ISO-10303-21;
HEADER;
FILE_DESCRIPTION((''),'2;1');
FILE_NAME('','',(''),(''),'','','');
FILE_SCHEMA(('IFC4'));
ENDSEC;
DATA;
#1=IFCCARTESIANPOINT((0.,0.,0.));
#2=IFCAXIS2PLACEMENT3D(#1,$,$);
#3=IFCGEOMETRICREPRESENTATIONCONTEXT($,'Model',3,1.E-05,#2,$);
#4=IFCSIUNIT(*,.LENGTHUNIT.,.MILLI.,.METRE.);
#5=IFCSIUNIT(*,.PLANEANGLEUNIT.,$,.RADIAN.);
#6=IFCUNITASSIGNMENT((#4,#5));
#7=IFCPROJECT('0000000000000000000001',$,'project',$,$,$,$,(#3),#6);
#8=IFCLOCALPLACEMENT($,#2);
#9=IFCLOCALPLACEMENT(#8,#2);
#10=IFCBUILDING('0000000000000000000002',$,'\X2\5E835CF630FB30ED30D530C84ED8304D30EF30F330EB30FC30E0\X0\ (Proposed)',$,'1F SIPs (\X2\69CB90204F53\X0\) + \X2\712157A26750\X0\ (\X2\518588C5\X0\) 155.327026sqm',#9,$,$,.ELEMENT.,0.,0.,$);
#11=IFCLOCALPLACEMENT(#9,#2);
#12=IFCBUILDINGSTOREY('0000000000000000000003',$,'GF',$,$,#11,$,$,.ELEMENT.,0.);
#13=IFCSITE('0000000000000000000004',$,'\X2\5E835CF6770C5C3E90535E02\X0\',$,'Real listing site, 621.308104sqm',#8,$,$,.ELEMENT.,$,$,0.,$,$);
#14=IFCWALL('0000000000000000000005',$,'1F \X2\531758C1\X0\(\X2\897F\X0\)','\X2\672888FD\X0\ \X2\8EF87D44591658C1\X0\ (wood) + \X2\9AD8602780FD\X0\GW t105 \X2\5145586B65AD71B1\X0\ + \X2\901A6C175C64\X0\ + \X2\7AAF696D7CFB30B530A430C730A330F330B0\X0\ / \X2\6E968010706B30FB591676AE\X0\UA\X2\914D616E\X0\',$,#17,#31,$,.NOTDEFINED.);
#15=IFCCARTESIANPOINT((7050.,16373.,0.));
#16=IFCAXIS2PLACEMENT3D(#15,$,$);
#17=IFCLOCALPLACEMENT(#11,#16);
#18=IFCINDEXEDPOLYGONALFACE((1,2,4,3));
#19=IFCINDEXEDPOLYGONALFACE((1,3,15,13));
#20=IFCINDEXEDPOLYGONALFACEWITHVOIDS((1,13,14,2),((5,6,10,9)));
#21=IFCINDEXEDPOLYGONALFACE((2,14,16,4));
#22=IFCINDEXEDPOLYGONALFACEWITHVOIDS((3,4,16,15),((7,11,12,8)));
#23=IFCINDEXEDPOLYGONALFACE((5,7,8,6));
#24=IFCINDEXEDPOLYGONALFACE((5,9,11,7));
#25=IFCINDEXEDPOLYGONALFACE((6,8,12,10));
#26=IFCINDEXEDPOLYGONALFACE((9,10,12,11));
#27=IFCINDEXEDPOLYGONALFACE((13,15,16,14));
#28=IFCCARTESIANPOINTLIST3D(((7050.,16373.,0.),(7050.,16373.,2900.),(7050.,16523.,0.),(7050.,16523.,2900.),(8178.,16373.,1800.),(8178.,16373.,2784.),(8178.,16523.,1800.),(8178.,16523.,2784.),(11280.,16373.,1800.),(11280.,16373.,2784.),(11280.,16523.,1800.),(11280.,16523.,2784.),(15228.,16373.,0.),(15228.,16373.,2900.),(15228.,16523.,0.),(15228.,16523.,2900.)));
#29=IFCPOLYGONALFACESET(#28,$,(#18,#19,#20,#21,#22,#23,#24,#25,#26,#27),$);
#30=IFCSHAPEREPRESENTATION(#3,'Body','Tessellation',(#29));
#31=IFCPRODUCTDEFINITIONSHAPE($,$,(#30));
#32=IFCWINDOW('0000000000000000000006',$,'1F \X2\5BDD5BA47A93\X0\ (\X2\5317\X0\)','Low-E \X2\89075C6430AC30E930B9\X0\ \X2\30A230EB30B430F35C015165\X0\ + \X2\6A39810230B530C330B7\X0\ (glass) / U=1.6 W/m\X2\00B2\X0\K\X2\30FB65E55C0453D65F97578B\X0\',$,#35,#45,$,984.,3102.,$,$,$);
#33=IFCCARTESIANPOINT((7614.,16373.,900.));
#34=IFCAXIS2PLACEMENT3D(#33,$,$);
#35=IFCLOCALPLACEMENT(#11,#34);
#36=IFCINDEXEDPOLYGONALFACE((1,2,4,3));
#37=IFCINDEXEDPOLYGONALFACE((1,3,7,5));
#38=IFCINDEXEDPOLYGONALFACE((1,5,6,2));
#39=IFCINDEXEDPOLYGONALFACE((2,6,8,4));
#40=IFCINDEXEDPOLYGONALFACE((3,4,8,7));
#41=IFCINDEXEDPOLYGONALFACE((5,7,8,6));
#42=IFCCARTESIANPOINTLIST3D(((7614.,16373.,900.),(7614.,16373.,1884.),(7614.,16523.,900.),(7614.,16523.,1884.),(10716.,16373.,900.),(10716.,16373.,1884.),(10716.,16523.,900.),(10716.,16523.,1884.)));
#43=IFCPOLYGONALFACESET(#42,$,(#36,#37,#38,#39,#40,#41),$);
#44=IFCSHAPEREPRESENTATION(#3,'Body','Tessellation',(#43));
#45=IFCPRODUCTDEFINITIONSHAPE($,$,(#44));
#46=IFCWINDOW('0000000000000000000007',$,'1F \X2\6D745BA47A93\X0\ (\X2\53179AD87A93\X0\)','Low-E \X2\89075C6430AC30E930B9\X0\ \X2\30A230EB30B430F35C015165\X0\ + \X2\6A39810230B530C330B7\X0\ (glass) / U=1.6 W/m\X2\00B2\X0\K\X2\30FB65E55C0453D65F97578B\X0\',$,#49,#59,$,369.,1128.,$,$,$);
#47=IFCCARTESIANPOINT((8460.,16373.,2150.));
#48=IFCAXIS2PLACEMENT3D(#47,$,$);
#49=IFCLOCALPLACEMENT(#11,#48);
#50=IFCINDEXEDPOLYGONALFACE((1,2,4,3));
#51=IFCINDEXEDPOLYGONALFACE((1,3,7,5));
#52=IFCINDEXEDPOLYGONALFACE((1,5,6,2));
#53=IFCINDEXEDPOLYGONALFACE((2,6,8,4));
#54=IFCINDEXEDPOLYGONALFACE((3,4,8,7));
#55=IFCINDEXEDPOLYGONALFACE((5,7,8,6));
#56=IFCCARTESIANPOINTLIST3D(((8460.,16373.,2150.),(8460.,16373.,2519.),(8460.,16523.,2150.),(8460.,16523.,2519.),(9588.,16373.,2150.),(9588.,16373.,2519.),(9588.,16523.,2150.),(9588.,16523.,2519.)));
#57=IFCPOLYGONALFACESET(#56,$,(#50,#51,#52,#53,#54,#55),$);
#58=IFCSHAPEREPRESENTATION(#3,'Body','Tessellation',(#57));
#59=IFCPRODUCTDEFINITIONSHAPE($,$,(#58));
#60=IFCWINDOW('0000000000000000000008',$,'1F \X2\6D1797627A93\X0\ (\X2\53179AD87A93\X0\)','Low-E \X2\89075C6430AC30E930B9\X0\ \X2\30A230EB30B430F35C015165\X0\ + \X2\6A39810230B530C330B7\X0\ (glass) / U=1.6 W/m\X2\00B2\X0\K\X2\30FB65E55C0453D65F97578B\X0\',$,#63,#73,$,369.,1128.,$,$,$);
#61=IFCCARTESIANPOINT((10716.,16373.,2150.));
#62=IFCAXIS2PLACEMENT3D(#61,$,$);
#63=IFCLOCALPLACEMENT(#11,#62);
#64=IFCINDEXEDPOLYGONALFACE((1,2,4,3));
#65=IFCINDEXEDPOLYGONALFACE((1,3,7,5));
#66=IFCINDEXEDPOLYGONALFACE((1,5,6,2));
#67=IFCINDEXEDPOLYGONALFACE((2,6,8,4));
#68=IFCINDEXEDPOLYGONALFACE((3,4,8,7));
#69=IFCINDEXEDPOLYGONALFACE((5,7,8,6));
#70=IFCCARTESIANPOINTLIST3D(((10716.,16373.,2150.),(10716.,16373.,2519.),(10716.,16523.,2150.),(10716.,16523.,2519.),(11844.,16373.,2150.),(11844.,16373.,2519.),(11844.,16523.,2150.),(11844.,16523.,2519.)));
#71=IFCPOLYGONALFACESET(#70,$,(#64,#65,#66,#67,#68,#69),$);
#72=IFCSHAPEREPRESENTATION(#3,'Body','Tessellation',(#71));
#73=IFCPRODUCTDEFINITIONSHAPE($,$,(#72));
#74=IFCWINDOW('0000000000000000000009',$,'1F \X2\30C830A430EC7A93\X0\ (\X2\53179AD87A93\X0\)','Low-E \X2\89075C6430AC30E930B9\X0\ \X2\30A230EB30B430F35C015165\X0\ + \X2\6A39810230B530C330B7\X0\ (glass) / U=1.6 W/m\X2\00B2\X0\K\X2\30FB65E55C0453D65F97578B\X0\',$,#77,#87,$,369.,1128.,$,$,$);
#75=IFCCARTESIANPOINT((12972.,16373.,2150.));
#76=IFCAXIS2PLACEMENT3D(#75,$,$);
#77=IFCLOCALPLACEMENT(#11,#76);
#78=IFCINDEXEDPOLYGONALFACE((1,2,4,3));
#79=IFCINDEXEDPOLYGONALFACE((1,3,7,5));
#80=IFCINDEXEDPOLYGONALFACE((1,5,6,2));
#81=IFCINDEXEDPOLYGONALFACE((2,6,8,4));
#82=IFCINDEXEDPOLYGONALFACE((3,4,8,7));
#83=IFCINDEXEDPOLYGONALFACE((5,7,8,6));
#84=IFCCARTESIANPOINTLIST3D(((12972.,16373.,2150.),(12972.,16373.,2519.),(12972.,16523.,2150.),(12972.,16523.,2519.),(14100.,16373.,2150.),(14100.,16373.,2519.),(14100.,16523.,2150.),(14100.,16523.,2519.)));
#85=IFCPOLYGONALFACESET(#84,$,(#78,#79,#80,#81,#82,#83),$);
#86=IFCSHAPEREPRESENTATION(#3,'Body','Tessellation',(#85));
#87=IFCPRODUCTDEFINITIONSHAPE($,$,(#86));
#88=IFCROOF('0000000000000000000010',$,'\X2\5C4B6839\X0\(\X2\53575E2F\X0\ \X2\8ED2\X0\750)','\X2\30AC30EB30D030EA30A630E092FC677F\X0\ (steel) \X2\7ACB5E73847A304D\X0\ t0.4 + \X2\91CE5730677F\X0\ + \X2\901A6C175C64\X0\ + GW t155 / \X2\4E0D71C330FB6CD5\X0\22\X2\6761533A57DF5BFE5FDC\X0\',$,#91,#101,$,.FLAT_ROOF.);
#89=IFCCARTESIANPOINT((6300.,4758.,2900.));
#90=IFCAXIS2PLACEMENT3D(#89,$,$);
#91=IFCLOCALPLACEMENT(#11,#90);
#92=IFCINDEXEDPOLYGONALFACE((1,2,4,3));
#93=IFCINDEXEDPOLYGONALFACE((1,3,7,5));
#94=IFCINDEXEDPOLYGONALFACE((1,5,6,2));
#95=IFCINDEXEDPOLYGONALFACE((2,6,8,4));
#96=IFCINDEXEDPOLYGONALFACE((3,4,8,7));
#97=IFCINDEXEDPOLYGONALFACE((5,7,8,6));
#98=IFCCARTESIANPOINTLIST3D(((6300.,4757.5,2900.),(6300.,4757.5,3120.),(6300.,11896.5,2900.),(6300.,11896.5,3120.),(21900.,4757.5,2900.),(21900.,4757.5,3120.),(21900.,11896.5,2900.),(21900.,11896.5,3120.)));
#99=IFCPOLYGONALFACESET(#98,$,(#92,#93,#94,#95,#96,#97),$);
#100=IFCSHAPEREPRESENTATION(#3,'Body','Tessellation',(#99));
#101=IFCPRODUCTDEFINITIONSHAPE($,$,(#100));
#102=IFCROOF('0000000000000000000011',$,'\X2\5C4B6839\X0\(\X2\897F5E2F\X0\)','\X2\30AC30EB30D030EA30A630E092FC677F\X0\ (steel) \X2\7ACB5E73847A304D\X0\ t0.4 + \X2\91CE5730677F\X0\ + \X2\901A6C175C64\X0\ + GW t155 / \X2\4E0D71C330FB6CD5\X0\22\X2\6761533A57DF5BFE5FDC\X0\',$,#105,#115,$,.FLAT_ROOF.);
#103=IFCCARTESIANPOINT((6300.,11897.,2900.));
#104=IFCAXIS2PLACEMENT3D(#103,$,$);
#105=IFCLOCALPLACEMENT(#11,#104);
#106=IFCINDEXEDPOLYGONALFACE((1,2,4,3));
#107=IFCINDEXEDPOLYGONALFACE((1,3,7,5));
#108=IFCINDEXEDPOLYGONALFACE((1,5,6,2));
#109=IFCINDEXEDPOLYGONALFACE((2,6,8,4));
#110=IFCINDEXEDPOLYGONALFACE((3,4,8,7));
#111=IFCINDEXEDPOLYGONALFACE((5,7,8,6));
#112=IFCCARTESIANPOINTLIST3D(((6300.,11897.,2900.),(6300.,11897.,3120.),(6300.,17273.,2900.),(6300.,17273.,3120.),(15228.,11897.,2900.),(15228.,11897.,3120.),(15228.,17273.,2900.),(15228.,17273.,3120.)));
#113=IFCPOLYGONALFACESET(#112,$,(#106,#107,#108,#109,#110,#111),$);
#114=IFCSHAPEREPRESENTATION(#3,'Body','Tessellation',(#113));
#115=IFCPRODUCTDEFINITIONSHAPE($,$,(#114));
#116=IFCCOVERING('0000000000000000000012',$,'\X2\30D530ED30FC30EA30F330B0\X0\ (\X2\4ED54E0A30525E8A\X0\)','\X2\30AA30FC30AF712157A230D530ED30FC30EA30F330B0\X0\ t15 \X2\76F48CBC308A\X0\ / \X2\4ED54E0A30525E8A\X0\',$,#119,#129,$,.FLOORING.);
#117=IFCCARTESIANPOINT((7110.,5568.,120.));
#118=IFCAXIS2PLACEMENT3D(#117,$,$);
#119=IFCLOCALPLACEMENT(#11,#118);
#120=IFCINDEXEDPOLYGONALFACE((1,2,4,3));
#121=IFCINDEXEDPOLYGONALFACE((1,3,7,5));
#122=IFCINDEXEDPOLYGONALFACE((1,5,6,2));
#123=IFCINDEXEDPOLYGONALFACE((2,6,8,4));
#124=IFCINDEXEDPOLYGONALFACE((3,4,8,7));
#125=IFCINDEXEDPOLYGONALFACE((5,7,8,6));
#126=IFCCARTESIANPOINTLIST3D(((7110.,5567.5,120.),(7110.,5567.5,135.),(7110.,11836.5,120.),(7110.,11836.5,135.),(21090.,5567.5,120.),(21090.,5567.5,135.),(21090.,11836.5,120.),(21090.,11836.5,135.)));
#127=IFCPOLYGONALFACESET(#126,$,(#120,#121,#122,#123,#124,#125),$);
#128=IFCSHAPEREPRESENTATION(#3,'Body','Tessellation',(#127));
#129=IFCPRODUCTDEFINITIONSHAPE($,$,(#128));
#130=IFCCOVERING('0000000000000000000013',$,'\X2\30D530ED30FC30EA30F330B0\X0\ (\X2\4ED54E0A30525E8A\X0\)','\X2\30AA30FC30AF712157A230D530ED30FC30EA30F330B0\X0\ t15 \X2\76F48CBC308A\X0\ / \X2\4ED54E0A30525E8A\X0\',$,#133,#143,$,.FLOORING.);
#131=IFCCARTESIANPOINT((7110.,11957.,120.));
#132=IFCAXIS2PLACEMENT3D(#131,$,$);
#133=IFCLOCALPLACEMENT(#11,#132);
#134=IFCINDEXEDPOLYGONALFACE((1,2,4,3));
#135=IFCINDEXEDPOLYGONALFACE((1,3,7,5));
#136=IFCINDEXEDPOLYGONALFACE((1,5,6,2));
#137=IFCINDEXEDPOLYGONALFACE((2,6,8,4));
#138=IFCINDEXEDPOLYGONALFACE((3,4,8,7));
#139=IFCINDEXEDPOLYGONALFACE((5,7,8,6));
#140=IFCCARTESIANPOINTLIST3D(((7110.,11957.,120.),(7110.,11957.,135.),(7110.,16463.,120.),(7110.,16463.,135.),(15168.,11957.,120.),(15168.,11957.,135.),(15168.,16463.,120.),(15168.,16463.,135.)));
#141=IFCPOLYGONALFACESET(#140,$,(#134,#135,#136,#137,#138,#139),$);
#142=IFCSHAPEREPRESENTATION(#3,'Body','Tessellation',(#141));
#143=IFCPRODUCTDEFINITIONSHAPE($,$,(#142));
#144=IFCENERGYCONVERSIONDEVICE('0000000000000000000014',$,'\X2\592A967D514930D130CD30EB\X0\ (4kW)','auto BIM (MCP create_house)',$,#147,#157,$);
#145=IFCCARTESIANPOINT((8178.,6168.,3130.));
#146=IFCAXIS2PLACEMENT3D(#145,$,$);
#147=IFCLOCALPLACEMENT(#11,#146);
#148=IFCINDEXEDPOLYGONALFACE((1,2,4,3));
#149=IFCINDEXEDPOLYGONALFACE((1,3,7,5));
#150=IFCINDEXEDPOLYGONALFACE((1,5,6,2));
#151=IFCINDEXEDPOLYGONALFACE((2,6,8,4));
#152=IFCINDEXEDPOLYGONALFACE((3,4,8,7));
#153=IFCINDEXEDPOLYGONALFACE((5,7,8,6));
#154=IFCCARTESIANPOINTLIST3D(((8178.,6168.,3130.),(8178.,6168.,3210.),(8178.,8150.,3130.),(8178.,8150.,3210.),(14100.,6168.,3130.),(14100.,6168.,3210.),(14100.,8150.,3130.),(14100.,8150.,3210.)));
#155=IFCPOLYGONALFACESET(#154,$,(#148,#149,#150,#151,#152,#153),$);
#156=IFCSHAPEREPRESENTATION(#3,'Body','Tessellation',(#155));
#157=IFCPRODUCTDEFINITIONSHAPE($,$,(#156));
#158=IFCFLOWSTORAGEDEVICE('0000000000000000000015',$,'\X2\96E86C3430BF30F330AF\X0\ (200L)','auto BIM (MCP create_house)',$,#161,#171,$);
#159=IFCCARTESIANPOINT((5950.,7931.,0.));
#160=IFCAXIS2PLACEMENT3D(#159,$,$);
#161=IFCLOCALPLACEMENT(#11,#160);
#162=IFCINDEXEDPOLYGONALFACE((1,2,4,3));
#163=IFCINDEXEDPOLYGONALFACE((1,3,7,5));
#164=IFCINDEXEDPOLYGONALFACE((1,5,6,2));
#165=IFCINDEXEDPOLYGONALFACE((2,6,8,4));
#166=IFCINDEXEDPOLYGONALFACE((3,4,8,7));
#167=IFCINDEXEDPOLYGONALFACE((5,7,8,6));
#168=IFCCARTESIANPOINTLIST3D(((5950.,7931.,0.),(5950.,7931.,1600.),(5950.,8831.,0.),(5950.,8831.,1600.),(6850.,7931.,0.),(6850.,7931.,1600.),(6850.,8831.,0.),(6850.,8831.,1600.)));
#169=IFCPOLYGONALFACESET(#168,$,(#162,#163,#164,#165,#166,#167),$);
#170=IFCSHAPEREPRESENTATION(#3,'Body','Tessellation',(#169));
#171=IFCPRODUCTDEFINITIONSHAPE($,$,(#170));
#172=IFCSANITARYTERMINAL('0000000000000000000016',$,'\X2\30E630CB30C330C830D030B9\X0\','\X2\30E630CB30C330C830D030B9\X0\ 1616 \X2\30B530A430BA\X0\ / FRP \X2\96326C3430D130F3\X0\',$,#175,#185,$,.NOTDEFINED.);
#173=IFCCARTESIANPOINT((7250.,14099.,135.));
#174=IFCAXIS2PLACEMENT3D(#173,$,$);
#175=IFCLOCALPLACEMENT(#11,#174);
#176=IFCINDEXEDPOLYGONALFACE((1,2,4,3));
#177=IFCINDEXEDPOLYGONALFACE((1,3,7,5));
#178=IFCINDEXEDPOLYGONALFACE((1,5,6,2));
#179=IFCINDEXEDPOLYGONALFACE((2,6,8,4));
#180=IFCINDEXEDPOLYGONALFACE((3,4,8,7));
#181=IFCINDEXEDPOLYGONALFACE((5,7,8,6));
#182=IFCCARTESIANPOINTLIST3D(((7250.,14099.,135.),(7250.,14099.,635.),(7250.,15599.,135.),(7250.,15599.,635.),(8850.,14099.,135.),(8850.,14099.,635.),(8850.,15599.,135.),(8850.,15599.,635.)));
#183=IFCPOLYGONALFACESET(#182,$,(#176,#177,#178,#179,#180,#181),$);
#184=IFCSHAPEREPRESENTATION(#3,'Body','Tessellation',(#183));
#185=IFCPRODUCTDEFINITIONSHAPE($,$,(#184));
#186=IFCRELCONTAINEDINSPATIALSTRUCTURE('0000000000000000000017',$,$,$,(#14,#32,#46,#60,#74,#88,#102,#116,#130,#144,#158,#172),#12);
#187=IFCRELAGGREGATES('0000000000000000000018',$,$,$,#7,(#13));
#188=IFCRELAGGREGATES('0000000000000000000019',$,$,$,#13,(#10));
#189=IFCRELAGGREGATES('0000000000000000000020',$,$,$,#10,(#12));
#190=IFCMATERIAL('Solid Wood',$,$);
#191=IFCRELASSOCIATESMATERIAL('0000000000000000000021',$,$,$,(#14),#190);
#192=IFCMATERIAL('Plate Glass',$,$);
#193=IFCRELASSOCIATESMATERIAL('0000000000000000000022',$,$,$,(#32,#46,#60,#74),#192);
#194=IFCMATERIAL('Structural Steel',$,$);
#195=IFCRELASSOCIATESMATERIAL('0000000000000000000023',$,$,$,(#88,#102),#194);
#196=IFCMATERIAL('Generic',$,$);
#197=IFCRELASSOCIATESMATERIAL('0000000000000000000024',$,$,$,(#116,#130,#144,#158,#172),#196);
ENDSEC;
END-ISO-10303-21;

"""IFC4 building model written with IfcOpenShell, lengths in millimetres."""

from ifc_helpers import new_model, si_unit, frame, frame_2d, origin, place, context, project, spatial, rectangle, extrude, material, element, fill, save


model = new_model("IFC4")

# Units and contexts
model_context = context("Model", 3, precision=1e-05, world=origin())
ifc_project = project(units=[si_unit("LENGTHUNIT", "METRE", prefix="MILLI"), si_unit("PLANEANGLEUNIT", "RADIAN")], contexts=[model_context])

# Site, building, storey
site_placement = place(None, origin())
site = spatial("IfcSite", under=ifc_project, at=site_placement, Name="広島県尾道市", ObjectType="Real listing site, 621.308104sqm", CompositionType="ELEMENT", RefElevation=0.0)
building_placement = place(site_placement, origin())
building = spatial("IfcBuilding", under=site, at=building_placement, Name="広島・ロフト付きワンルーム (Proposed)", ObjectType="1F SIPs (構造体) + 無垢材 (内装) 155.327026sqm", CompositionType="ELEMENT", ElevationOfRefHeight=0.0, ElevationOfTerrain=0.0)
storey_placement = place(building_placement, origin())
storey = spatial("IfcBuildingStorey", under=building, at=storey_placement, Name="GF", CompositionType="ELEMENT", Elevation=0.0)

# Shared definitions
ifc_material_1 = material(Name="Solid Wood")

# Shared definitions
ifc_material_2 = material(Name="Plate Glass")

# Wall, openings, windows
wall_1_placement = place(storey_placement, frame((7050.0, 16373.0, 0.0)))
wall_1 = element("IfcWall", 1, at=wall_1_placement, inside=storey, material=ifc_material_1, Name="1F 北壁(西)", Description="木製 軸組外壁 (wood) + 高性能GW t105 充填断熱 + 通気層 + 窯業系サイディング / 準耐火・外皮UA配慮", PredefinedType="NOTDEFINED", context=model_context, shape_type="SweptSolid", body=[
    extrude(rectangle(XDim=8178.0, YDim=150.0, at=frame_2d((4089.0, 75.0))), frame((7050.0, 16373.0, 0.0)), (0.0, 0.0, 1.0), 2900.0),
])
opening_1_placement = place(storey_placement, frame((7614.0, 16373.0, 900.0)))
opening_1 = element("IfcOpeningElement", 2, at=opening_1_placement, cuts=wall_1, PredefinedType="NOTDEFINED", context=model_context, shape_type="SweptSolid", body=[
    extrude(rectangle(XDim=3102.0, YDim=150.0, at=frame_2d((1551.0, 75.0))), frame((7614.0, 16373.0, 900.0)), (0.0, 0.0, 1.0), 984.0),
])
opening_2_placement = place(storey_placement, frame((8460.0, 16373.0, 2150.0)))
opening_2 = element("IfcOpeningElement", 3, at=opening_2_placement, cuts=wall_1, PredefinedType="NOTDEFINED", context=model_context, shape_type="SweptSolid", body=[
    extrude(rectangle(XDim=1128.0, YDim=150.0, at=frame_2d((564.0, 75.0))), frame((8460.0, 16373.0, 2150.0)), (0.0, 0.0, 1.0), 369.0),
])
opening_3_placement = place(storey_placement, frame((10716.0, 16373.0, 2150.0)))
opening_3 = element("IfcOpeningElement", 4, at=opening_3_placement, cuts=wall_1, PredefinedType="NOTDEFINED", context=model_context, shape_type="SweptSolid", body=[
    extrude(rectangle(XDim=1128.0, YDim=150.0, at=frame_2d((564.0, 75.0))), frame((10716.0, 16373.0, 2150.0)), (0.0, 0.0, 1.0), 369.0),
])
opening_4_placement = place(storey_placement, frame((12972.0, 16373.0, 2150.0)))
opening_4 = element("IfcOpeningElement", 5, at=opening_4_placement, cuts=wall_1, PredefinedType="NOTDEFINED", context=model_context, shape_type="SweptSolid", body=[
    extrude(rectangle(XDim=1128.0, YDim=150.0, at=frame_2d((564.0, 75.0))), frame((12972.0, 16373.0, 2150.0)), (0.0, 0.0, 1.0), 369.0),
])
window_1_placement = place(storey_placement, frame((7614.0, 16373.0, 900.0)))
window_1 = element("IfcWindow", 6, at=window_1_placement, inside=storey, material=ifc_material_2, Name="1F 寝室窓 (北)", Description="Low-E 複層ガラス アルゴン封入 + 樹脂サッシ (glass) / U=1.6 W/m²K・日射取得型", OverallHeight=984.0, OverallWidth=3102.0, context=model_context, shape_type="SweptSolid", body=[
    extrude(rectangle(XDim=3102.0, YDim=150.0, at=frame_2d((1551.0, 75.0))), frame((7614.0, 16373.0, 900.0)), (0.0, 0.0, 1.0), 984.0),
])
fill(opening_1, window_1)
window_2_placement = place(storey_placement, frame((8460.0, 16373.0, 2150.0)))
window_2 = element("IfcWindow", 7, at=window_2_placement, inside=storey, material=ifc_material_2, Name="1F 浴室窓 (北高窓)", Description="Low-E 複層ガラス アルゴン封入 + 樹脂サッシ (glass) / U=1.6 W/m²K・日射取得型", OverallHeight=369.0, OverallWidth=1128.0, context=model_context, shape_type="SweptSolid", body=[
    extrude(rectangle(XDim=1128.0, YDim=150.0, at=frame_2d((564.0, 75.0))), frame((8460.0, 16373.0, 2150.0)), (0.0, 0.0, 1.0), 369.0),
])
fill(opening_2, window_2)
window_3_placement = place(storey_placement, frame((10716.0, 16373.0, 2150.0)))
window_3 = element("IfcWindow", 8, at=window_3_placement, inside=storey, material=ifc_material_2, Name="1F 洗面窓 (北高窓)", Description="Low-E 複層ガラス アルゴン封入 + 樹脂サッシ (glass) / U=1.6 W/m²K・日射取得型", OverallHeight=369.0, OverallWidth=1128.0, context=model_context, shape_type="SweptSolid", body=[
    extrude(rectangle(XDim=1128.0, YDim=150.0, at=frame_2d((564.0, 75.0))), frame((10716.0, 16373.0, 2150.0)), (0.0, 0.0, 1.0), 369.0),
])
fill(opening_3, window_3)
window_4_placement = place(storey_placement, frame((12972.0, 16373.0, 2150.0)))
window_4 = element("IfcWindow", 9, at=window_4_placement, inside=storey, material=ifc_material_2, Name="1F トイレ窓 (北高窓)", Description="Low-E 複層ガラス アルゴン封入 + 樹脂サッシ (glass) / U=1.6 W/m²K・日射取得型", OverallHeight=369.0, OverallWidth=1128.0, context=model_context, shape_type="SweptSolid", body=[
    extrude(rectangle(XDim=1128.0, YDim=150.0, at=frame_2d((564.0, 75.0))), frame((12972.0, 16373.0, 2150.0)), (0.0, 0.0, 1.0), 369.0),
])
fill(opening_4, window_4)

# Roofs
ifc_material_3 = material(Name="Structural Steel")
roof_1_placement = place(storey_placement, frame((6300.0, 4758.0, 2900.0)))
element("IfcRoof", 10, at=roof_1_placement, inside=storey, material=ifc_material_3, Name="屋根(南帯 軒750)", Description="ガルバリウム鋼板 (steel) 立平葺き t0.4 + 野地板 + 通気層 + GW t155 / 不燃・法22条区域対応", PredefinedType="FLAT_ROOF", context=model_context, shape_type="SweptSolid", body=[
    extrude(rectangle(XDim=15600.0, YDim=7139.0, at=frame_2d((7800.0, 3569.0))), frame((6300.0, 4758.0, 2900.0)), (0.0, 0.0, 1.0), 220.0),
])
roof_2_placement = place(storey_placement, frame((6300.0, 11897.0, 2900.0)))
element("IfcRoof", 11, at=roof_2_placement, inside=storey, material=ifc_material_3, Name="屋根(西帯)", Description="ガルバリウム鋼板 (steel) 立平葺き t0.4 + 野地板 + 通気層 + GW t155 / 不燃・法22条区域対応", PredefinedType="FLAT_ROOF", context=model_context, shape_type="SweptSolid", body=[
    extrude(rectangle(XDim=8928.0, YDim=5376.0, at=frame_2d((4464.0, 2688.0))), frame((6300.0, 11897.0, 2900.0)), (0.0, 0.0, 1.0), 220.0),
])

# Coverings
ifc_material_4 = material(Name="Generic")
covering_1_placement = place(storey_placement, frame((7110.0, 5568.0, 120.0)))
element("IfcCovering", 12, at=covering_1_placement, inside=storey, material=ifc_material_4, Name="フローリング (仕上げ床)", Description="オーク無垢フローリング t15 直貼り / 仕上げ床", PredefinedType="FLOORING", context=model_context, shape_type="SweptSolid", body=[
    extrude(rectangle(XDim=13980.0, YDim=6269.0, at=frame_2d((6990.0, 3134.0))), frame((7110.0, 5568.0, 120.0)), (0.0, 0.0, 1.0), 15.0),
])
covering_2_placement = place(storey_placement, frame((7110.0, 11957.0, 120.0)))
element("IfcCovering", 13, at=covering_2_placement, inside=storey, material=ifc_material_4, Name="フローリング (仕上げ床)", Description="オーク無垢フローリング t15 直貼り / 仕上げ床", PredefinedType="FLOORING", context=model_context, shape_type="SweptSolid", body=[
    extrude(rectangle(XDim=8058.0, YDim=4506.0, at=frame_2d((4029.0, 2253.0))), frame((7110.0, 11957.0, 120.0)), (0.0, 0.0, 1.0), 15.0),
])

# Energy conversion device
energy_conversion_device_placement = place(storey_placement, frame((8178.0, 6168.0, 3130.0)))
element("IfcEnergyConversionDevice", 14, at=energy_conversion_device_placement, inside=storey, material=ifc_material_4, Name="太陽光パネル (4kW)", Description="auto BIM (MCP create_house)", context=model_context, shape_type="SweptSolid", body=[
    extrude(rectangle(XDim=5922.0, YDim=1982.0, at=frame_2d((2961.0, 991.0))), frame((8178.0, 6168.0, 3130.0)), (0.0, 0.0, 1.0), 80.0),
])

# Flow storage device
flow_storage_device_placement = place(storey_placement, frame((5950.0, 7931.0, 0.0)))
element("IfcFlowStorageDevice", 15, at=flow_storage_device_placement, inside=storey, material=ifc_material_4, Name="雨水タンク (200L)", Description="auto BIM (MCP create_house)", context=model_context, shape_type="SweptSolid", body=[
    extrude(rectangle(XDim=900.0, YDim=900.0, at=frame_2d((450.0, 450.0))), frame((5950.0, 7931.0, 0.0)), (0.0, 0.0, 1.0), 1600.0),
])

# Sanitary terminal
sanitary_terminal_placement = place(storey_placement, frame((7250.0, 14099.0, 135.0)))
element("IfcSanitaryTerminal", 16, at=sanitary_terminal_placement, inside=storey, material=ifc_material_4, Name="ユニットバス", Description="ユニットバス 1616 サイズ / FRP 防水パン", PredefinedType="NOTDEFINED", context=model_context, shape_type="SweptSolid", body=[
    extrude(rectangle(XDim=1600.0, YDim=1500.0, at=frame_2d((800.0, 750.0))), frame((7250.0, 14099.0, 135.0)), (0.0, 0.0, 1.0), 500.0),
])

save(model, "model.ifc")
